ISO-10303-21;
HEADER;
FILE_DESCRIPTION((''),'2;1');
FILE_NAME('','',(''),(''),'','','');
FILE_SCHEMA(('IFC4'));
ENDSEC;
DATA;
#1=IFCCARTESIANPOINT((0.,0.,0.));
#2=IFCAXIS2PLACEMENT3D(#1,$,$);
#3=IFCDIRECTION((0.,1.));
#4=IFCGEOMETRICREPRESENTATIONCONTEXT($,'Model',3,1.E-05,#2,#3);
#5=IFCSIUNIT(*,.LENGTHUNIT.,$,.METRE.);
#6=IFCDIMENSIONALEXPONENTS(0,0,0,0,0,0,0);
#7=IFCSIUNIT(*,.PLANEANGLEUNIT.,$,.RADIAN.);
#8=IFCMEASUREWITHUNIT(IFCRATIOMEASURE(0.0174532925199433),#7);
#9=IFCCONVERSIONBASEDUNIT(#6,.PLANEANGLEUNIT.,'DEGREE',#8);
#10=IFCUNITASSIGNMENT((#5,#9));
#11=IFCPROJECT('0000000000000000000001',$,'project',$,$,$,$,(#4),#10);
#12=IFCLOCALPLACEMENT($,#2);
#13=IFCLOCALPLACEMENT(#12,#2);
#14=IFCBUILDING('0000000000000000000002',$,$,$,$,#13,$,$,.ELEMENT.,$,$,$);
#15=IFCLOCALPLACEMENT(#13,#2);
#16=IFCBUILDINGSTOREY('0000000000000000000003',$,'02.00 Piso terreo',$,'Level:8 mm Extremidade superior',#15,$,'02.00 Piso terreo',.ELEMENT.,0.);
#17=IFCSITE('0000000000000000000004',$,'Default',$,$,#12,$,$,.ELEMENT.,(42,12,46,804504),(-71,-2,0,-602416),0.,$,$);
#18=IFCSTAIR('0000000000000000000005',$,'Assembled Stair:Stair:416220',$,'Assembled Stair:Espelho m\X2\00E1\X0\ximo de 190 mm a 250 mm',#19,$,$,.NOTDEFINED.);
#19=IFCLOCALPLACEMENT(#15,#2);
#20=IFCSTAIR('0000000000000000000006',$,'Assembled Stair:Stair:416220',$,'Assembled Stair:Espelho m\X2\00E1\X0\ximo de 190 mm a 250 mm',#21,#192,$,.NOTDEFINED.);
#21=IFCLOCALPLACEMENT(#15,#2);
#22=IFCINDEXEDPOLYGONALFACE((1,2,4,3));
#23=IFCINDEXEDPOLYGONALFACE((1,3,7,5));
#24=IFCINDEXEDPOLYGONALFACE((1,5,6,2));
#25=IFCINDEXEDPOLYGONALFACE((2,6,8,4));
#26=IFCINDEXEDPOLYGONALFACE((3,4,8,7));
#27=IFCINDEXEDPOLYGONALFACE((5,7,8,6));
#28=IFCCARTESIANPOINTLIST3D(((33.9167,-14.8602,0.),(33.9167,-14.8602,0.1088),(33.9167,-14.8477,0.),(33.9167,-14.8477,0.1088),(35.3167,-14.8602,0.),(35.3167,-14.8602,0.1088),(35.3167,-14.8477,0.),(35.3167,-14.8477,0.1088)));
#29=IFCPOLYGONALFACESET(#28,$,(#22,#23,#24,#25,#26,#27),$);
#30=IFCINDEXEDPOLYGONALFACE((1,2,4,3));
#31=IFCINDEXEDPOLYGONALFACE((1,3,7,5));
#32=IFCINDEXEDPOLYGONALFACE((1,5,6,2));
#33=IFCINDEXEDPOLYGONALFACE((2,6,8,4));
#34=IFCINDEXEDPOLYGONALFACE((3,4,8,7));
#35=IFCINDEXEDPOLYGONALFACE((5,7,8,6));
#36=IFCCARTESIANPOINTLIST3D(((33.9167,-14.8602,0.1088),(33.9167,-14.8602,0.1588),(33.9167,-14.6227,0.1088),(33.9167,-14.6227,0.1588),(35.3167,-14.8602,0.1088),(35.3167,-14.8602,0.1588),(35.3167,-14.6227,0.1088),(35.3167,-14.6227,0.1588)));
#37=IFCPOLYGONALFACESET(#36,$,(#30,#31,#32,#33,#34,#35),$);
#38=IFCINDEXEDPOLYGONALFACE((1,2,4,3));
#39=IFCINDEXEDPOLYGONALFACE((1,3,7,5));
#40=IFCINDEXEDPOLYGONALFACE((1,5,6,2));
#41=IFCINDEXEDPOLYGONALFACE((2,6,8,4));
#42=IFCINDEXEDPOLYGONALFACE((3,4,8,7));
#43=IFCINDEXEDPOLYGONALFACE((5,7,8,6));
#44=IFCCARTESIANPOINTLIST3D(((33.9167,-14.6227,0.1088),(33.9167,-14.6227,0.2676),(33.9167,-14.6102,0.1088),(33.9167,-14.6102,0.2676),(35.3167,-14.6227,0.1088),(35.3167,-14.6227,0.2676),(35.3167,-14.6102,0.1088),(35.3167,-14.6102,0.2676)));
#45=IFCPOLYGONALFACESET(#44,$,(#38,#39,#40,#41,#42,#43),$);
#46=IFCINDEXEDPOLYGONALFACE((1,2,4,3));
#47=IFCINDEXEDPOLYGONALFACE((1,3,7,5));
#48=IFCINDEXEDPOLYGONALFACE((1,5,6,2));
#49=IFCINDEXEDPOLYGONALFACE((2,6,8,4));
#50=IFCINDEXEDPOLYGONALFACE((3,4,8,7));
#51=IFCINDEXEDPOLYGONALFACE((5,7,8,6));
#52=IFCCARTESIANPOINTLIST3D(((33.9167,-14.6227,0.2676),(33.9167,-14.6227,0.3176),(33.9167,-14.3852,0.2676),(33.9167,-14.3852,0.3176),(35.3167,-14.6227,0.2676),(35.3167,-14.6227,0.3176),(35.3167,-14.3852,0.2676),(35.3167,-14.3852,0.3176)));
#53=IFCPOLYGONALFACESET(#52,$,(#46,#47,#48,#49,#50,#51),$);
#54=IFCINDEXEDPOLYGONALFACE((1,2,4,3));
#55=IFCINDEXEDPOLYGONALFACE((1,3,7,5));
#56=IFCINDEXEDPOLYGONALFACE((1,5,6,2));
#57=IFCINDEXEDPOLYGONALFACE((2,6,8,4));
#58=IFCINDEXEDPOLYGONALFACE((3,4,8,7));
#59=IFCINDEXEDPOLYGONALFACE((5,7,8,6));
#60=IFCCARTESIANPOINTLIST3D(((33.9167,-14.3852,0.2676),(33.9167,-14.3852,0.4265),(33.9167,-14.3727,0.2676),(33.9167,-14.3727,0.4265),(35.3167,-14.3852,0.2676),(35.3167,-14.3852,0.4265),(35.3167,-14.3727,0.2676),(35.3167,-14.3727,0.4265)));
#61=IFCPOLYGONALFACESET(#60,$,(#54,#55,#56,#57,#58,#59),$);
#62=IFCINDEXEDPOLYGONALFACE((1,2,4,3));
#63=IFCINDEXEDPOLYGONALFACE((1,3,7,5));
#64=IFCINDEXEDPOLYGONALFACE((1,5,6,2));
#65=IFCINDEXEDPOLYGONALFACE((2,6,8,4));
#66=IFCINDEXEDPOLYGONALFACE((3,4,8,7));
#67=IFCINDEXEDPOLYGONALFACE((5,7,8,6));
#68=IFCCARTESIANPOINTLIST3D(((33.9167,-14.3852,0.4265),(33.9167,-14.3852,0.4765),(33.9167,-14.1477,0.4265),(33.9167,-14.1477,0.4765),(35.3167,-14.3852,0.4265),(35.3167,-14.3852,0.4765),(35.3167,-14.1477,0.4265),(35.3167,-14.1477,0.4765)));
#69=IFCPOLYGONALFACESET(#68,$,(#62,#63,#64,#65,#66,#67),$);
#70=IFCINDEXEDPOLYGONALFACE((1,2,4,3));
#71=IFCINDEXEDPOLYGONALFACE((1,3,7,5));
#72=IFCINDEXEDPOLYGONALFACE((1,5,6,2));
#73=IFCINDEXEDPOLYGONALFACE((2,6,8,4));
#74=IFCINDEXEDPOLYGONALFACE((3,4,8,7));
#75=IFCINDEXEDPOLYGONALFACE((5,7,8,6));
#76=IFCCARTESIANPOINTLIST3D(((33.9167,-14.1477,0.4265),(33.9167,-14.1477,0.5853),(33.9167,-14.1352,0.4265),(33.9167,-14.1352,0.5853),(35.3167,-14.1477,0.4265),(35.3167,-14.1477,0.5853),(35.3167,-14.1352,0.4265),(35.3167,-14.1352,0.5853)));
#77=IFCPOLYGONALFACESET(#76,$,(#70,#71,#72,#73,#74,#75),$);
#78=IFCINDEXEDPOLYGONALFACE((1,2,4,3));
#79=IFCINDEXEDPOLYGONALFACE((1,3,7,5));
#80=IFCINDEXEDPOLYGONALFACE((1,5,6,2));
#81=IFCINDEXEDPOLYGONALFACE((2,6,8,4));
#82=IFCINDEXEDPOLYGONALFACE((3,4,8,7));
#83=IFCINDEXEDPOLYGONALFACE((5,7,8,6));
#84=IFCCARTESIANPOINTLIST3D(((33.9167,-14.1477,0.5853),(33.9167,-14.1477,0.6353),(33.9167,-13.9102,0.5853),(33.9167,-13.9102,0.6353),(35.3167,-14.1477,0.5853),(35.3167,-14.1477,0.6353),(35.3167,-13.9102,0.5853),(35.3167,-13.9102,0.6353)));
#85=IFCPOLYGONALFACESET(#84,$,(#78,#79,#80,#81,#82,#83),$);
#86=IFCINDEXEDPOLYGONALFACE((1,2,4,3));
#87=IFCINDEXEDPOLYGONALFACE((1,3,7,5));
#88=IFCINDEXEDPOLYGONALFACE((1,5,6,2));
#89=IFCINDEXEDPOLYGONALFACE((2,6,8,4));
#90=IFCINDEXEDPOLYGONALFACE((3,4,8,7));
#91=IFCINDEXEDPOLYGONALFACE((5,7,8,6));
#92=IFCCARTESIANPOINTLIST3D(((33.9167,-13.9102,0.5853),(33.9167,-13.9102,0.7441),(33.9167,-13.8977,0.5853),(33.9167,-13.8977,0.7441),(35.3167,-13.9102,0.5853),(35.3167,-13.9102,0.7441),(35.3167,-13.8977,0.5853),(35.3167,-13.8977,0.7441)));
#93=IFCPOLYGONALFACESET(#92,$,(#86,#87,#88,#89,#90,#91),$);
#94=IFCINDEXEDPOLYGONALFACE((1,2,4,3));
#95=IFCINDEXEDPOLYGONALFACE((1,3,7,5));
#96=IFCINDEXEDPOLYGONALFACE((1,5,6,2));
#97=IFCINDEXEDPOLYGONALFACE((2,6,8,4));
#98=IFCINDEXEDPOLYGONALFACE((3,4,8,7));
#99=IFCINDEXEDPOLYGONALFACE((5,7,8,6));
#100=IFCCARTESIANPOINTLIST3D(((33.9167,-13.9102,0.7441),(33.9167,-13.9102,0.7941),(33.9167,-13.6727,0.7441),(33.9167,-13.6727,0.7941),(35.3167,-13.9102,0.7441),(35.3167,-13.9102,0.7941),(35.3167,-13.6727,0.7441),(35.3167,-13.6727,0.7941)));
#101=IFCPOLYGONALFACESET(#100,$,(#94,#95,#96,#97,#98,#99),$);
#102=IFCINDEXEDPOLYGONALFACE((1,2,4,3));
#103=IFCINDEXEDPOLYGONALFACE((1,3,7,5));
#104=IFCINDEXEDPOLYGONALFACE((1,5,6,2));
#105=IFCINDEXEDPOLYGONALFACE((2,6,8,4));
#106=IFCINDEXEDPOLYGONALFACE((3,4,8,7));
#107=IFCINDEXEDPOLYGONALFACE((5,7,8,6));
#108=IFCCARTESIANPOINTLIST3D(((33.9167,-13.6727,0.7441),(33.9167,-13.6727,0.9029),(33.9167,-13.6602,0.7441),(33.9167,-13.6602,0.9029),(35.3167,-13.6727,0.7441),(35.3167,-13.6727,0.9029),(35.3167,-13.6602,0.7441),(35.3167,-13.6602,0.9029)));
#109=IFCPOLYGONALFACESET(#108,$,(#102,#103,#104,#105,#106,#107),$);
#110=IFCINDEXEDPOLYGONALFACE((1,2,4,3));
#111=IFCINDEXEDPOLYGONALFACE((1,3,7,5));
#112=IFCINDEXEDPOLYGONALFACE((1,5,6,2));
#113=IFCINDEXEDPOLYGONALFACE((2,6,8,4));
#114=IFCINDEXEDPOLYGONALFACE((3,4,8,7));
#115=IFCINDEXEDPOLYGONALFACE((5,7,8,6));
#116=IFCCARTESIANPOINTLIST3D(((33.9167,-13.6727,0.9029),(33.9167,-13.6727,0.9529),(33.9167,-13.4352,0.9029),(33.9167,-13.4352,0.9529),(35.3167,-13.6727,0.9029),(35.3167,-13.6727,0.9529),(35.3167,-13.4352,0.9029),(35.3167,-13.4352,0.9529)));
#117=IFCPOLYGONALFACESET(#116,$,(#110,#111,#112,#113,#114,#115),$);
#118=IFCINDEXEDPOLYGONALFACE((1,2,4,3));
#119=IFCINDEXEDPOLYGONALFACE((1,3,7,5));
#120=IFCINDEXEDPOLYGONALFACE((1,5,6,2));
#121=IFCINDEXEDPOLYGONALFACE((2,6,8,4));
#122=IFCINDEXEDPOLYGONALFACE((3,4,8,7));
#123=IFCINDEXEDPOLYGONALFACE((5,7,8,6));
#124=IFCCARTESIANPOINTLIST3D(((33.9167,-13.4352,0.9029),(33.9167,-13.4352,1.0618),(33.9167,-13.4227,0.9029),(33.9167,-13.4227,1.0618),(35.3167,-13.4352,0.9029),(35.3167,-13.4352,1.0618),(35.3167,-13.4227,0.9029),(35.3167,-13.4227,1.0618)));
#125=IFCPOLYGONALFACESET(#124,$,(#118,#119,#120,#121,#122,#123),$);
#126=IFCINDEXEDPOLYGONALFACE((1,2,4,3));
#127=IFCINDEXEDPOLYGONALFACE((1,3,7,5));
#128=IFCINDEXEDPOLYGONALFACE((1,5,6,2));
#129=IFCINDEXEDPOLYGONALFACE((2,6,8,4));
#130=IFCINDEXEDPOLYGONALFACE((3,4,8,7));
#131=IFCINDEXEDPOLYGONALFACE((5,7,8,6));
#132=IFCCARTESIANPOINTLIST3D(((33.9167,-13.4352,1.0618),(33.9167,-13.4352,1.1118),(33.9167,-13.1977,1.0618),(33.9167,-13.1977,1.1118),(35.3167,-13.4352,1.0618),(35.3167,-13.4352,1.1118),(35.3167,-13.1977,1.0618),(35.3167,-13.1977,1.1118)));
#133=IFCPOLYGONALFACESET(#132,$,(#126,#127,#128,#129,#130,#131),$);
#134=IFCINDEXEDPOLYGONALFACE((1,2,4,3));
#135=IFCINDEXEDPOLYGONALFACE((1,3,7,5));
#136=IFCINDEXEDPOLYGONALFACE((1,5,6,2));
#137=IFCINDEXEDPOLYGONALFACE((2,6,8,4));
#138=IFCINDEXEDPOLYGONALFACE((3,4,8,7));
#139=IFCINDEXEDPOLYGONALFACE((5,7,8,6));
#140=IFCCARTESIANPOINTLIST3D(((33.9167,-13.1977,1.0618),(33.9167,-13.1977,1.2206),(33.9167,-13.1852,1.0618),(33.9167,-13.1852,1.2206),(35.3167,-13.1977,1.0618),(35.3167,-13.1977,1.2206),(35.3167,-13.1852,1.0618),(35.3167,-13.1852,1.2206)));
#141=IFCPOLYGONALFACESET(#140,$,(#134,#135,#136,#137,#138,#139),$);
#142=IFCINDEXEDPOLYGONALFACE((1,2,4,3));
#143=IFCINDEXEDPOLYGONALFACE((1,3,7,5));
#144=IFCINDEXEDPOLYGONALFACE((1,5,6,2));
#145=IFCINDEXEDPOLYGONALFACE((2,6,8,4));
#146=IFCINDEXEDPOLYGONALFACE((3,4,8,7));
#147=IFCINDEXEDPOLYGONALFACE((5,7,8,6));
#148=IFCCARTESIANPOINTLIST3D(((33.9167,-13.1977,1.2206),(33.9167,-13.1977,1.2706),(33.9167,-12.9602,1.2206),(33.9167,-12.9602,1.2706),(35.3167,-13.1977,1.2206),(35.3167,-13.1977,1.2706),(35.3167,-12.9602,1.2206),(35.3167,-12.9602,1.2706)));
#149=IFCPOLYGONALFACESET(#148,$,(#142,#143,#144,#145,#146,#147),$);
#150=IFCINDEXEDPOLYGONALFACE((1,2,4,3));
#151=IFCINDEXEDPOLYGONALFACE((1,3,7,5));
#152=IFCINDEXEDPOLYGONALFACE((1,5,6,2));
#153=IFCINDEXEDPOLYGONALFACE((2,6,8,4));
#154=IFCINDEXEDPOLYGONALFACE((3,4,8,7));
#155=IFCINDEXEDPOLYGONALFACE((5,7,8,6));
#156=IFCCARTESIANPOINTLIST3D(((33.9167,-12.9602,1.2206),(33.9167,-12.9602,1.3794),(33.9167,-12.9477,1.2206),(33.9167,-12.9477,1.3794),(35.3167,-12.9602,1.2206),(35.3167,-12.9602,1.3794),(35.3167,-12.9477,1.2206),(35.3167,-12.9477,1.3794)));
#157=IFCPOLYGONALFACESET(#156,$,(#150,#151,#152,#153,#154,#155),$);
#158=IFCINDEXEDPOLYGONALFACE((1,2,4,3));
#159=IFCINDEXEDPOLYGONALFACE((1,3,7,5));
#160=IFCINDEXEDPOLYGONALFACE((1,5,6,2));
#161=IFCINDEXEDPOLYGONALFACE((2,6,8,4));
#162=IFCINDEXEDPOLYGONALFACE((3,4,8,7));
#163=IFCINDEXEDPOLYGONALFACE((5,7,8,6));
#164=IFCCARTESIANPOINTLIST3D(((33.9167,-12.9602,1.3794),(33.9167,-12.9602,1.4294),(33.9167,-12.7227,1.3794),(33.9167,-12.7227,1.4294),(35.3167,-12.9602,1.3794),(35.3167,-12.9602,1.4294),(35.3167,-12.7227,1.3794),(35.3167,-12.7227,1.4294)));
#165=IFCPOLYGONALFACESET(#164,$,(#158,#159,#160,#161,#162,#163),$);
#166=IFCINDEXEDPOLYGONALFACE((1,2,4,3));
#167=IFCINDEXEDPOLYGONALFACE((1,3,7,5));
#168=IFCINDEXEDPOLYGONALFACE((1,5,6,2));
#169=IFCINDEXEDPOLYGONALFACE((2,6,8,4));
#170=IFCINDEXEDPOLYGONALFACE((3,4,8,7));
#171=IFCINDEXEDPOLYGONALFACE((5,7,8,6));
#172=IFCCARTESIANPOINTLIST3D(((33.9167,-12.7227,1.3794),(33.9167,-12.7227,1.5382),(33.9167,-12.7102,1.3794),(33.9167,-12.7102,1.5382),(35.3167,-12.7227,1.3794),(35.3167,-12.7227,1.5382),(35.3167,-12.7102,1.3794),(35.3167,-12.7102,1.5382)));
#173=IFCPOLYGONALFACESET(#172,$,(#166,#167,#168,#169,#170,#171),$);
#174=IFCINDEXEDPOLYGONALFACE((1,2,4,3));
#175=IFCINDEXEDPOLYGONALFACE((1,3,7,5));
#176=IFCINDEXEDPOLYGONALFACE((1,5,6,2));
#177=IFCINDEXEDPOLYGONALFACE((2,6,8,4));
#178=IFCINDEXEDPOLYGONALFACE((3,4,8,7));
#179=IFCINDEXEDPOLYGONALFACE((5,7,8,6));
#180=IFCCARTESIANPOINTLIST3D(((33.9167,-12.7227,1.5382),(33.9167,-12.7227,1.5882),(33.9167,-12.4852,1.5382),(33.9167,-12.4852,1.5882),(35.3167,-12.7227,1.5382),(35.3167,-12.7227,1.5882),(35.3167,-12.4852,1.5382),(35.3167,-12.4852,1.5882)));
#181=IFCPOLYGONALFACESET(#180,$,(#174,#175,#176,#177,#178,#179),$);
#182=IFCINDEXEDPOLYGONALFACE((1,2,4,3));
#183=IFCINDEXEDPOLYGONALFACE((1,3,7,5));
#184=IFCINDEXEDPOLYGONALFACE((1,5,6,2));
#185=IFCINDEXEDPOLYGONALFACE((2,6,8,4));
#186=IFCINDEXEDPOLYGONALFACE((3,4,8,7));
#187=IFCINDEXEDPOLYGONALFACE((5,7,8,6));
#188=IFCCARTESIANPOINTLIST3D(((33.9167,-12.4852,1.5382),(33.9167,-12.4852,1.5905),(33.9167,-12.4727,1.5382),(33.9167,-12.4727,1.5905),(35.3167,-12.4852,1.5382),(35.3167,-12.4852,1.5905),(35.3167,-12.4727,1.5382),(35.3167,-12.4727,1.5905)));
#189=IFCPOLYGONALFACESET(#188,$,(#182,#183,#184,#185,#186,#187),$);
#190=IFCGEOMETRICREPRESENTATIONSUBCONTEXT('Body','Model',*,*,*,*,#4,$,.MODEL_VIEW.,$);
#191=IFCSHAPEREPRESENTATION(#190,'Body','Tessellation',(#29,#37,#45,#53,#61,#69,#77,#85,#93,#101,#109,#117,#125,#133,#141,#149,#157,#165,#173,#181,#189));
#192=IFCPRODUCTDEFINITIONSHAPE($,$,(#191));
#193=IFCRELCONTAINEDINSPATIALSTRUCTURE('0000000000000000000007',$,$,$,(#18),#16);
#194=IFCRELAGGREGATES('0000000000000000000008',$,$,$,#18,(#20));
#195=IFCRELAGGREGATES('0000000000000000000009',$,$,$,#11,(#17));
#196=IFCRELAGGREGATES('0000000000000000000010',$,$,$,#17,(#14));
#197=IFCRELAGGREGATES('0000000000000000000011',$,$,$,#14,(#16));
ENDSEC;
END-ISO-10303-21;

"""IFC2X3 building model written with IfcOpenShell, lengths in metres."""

from ifc_helpers import new_model, entity, si_unit, converted_unit, direction, frame, frame_2d, origin, place, context, subcontext, project, spatial, rectangle, extrude, element, aggregate, save


model = new_model("IFC2X3")

# Units and contexts
model_context = context("Model", 3, precision=1e-05, world=origin(), true_north=direction((0.0, 1.0)))
body_context = subcontext(model_context, "Body", "Model", "MODEL_VIEW")
ifc_project = project(units=[si_unit("LENGTHUNIT", "METRE"), converted_unit("PLANEANGLEUNIT", "DEGREE", entity("IfcRatioMeasure", 0.0174532925199433), si_unit("PLANEANGLEUNIT", "RADIAN"), dimensions=[0, 0, 0, 0, 0, 0, 0])], contexts=[model_context])

# Site, building, storey
site_placement = place(None, origin())
site = spatial("IfcSite", under=ifc_project, at=site_placement, Name="Default", CompositionType="ELEMENT", RefLatitude=(42, 12, 46, 804504), RefLongitude=(-71, -2, 0, -602416), RefElevation=0.0)
building_placement = place(site_placement, origin())
building = spatial("IfcBuilding", under=site, at=building_placement, CompositionType="ELEMENT")
storey_placement = place(building_placement, origin())
storey = spatial("IfcBuildingStorey", under=building, at=storey_placement, Name="02.00 Piso terreo", ObjectType="Level:8 mm Extremidade superior", LongName="02.00 Piso terreo", CompositionType="ELEMENT", Elevation=0.0)

# Stairs
stair_1_placement = place(storey_placement, frame((33.9167, -14.8602, 0.0)))
stair_1 = element("IfcStair", 1, at=stair_1_placement, inside=storey, Name="Assembled Stair:Stair:416220", ObjectType="Assembled Stair:Espelho máximo de 190 mm a 250 mm", ShapeType="NOTDEFINED")
stair_2_placement = place(stair_1_placement, origin())
stair_2 = element("IfcStair", 2, at=stair_2_placement, Name="Assembled Stair:Stair:416220", ObjectType="Assembled Stair:Espelho máximo de 190 mm a 250 mm", ShapeType="NOTDEFINED", context=body_context, shape_type="SweptSolid", body=[
    extrude(rectangle(XDim=1.4, YDim=0.0125, at=frame_2d((0.0, 0.0), x_axis=(1.0, 0.0))), frame((0.7, 0.0063, 0.0), z_axis=(0.0, 0.0, 1.0), x_axis=(-1.0, 0.0, 0.0)), (0.0, 0.0, 1.0), 0.1088),
    extrude(rectangle(XDim=0.2375, YDim=1.4, at=frame_2d((0.0, 0.0), x_axis=(1.0, 0.0))), frame((0.7, 0.1187, 0.1088), z_axis=(0.0, 0.0, 1.0), x_axis=(0.0, -1.0, 0.0)), (0.0, 0.0, 1.0), 0.05),
    extrude(rectangle(XDim=1.4, YDim=0.0125, at=frame_2d((0.0, 0.0), x_axis=(1.0, 0.0))), frame((0.7, 0.2437, 0.1088), z_axis=(0.0, 0.0, 1.0), x_axis=(-1.0, 0.0, 0.0)), (0.0, 0.0, 1.0), 0.1588),
    extrude(rectangle(XDim=0.2375, YDim=1.4, at=frame_2d((0.0, 0.0), x_axis=(1.0, 0.0))), frame((0.7, 0.3563, 0.2676), z_axis=(0.0, 0.0, 1.0), x_axis=(0.0, -1.0, 0.0)), (0.0, 0.0, 1.0), 0.05),
    extrude(rectangle(XDim=1.4, YDim=0.0125, at=frame_2d((0.0, 0.0), x_axis=(1.0, 0.0))), frame((0.7, 0.4812, 0.2676), z_axis=(0.0, 0.0, 1.0), x_axis=(-1.0, 0.0, 0.0)), (0.0, 0.0, 1.0), 0.1588),
    extrude(rectangle(XDim=0.2375, YDim=1.4, at=frame_2d((0.0, 0.0), x_axis=(1.0, 0.0))), frame((0.7, 0.5938, 0.4265), z_axis=(0.0, 0.0, 1.0), x_axis=(0.0, -1.0, 0.0)), (0.0, 0.0, 1.0), 0.05),
    extrude(rectangle(XDim=1.4, YDim=0.0125, at=frame_2d((0.0, 0.0), x_axis=(1.0, 0.0))), frame((0.7, 0.7188, 0.4265), z_axis=(0.0, 0.0, 1.0), x_axis=(-1.0, 0.0, 0.0)), (0.0, 0.0, 1.0), 0.1588),
    extrude(rectangle(XDim=0.2375, YDim=1.4, at=frame_2d((0.0, 0.0), x_axis=(1.0, 0.0))), frame((0.7, 0.8313, 0.5853), z_axis=(0.0, 0.0, 1.0), x_axis=(0.0, -1.0, 0.0)), (0.0, 0.0, 1.0), 0.05),
    extrude(rectangle(XDim=1.4, YDim=0.0125, at=frame_2d((0.0, 0.0), x_axis=(1.0, 0.0))), frame((0.7, 0.9562, 0.5853), z_axis=(0.0, 0.0, 1.0), x_axis=(-1.0, 0.0, 0.0)), (0.0, 0.0, 1.0), 0.1588),
    extrude(rectangle(XDim=0.2375, YDim=1.4, at=frame_2d((0.0, 0.0), x_axis=(1.0, 0.0))), frame((0.7, 1.0688, 0.7441), z_axis=(0.0, 0.0, 1.0), x_axis=(0.0, -1.0, 0.0)), (0.0, 0.0, 1.0), 0.05),
    extrude(rectangle(XDim=1.4, YDim=0.0125, at=frame_2d((0.0, 0.0), x_axis=(1.0, 0.0))), frame((0.7, 1.1938, 0.7441), z_axis=(0.0, 0.0, 1.0), x_axis=(-1.0, 0.0, 0.0)), (0.0, 0.0, 1.0), 0.1588),
    extrude(rectangle(XDim=0.2375, YDim=1.4, at=frame_2d((0.0, 0.0), x_axis=(1.0, 0.0))), frame((0.7, 1.3062, 0.9029), z_axis=(0.0, 0.0, 1.0), x_axis=(0.0, -1.0, 0.0)), (0.0, 0.0, 1.0), 0.05),
    extrude(rectangle(XDim=1.4, YDim=0.0125, at=frame_2d((0.0, 0.0), x_axis=(1.0, 0.0))), frame((0.7, 1.4312, 0.9029), z_axis=(0.0, 0.0, 1.0), x_axis=(-1.0, 0.0, 0.0)), (0.0, 0.0, 1.0), 0.1588),
    extrude(rectangle(XDim=0.2375, YDim=1.4, at=frame_2d((0.0, 0.0), x_axis=(1.0, 0.0))), frame((0.7, 1.5437, 1.0618), z_axis=(0.0, 0.0, 1.0), x_axis=(0.0, -1.0, 0.0)), (0.0, 0.0, 1.0), 0.05),
    extrude(rectangle(XDim=1.4, YDim=0.0125, at=frame_2d((0.0, 0.0), x_axis=(1.0, 0.0))), frame((0.7, 1.6688, 1.0618), z_axis=(0.0, 0.0, 1.0), x_axis=(-1.0, 0.0, 0.0)), (0.0, 0.0, 1.0), 0.1588),
    extrude(rectangle(XDim=0.2375, YDim=1.4, at=frame_2d((0.0, 0.0), x_axis=(1.0, 0.0))), frame((0.7, 1.7813, 1.2206), z_axis=(0.0, 0.0, 1.0), x_axis=(0.0, -1.0, 0.0)), (0.0, 0.0, 1.0), 0.05),
    extrude(rectangle(XDim=1.4, YDim=0.0125, at=frame_2d((0.0, 0.0), x_axis=(1.0, 0.0))), frame((0.7, 1.9062, 1.2206), z_axis=(0.0, 0.0, 1.0), x_axis=(-1.0, 0.0, 0.0)), (0.0, 0.0, 1.0), 0.1588),
    extrude(rectangle(XDim=0.2375, YDim=1.4, at=frame_2d((0.0, 0.0), x_axis=(1.0, 0.0))), frame((0.7, 2.0187, 1.3794), z_axis=(0.0, 0.0, 1.0), x_axis=(0.0, -1.0, 0.0)), (0.0, 0.0, 1.0), 0.05),
    extrude(rectangle(XDim=1.4, YDim=0.0125, at=frame_2d((0.0, 0.0), x_axis=(1.0, 0.0))), frame((0.7, 2.1437, 1.3794), z_axis=(0.0, 0.0, 1.0), x_axis=(-1.0, 0.0, 0.0)), (0.0, 0.0, 1.0), 0.1588),
    extrude(rectangle(XDim=0.2375, YDim=1.4, at=frame_2d((0.0, 0.0), x_axis=(1.0, 0.0))), frame((0.7, 2.2563, 1.5382), z_axis=(0.0, 0.0, 1.0), x_axis=(0.0, -1.0, 0.0)), (0.0, 0.0, 1.0), 0.05),
    extrude(rectangle(XDim=1.4, YDim=0.0125, at=frame_2d((0.0, 0.0), x_axis=(1.0, 0.0))), frame((0.7, 2.3813, 1.5382), z_axis=(0.0, 0.0, 1.0), x_axis=(-1.0, 0.0, 0.0)), (0.0, 0.0, 1.0), 0.0522),
])
aggregate(stair_1, [stair_2])

save(model, "model.ifc")
